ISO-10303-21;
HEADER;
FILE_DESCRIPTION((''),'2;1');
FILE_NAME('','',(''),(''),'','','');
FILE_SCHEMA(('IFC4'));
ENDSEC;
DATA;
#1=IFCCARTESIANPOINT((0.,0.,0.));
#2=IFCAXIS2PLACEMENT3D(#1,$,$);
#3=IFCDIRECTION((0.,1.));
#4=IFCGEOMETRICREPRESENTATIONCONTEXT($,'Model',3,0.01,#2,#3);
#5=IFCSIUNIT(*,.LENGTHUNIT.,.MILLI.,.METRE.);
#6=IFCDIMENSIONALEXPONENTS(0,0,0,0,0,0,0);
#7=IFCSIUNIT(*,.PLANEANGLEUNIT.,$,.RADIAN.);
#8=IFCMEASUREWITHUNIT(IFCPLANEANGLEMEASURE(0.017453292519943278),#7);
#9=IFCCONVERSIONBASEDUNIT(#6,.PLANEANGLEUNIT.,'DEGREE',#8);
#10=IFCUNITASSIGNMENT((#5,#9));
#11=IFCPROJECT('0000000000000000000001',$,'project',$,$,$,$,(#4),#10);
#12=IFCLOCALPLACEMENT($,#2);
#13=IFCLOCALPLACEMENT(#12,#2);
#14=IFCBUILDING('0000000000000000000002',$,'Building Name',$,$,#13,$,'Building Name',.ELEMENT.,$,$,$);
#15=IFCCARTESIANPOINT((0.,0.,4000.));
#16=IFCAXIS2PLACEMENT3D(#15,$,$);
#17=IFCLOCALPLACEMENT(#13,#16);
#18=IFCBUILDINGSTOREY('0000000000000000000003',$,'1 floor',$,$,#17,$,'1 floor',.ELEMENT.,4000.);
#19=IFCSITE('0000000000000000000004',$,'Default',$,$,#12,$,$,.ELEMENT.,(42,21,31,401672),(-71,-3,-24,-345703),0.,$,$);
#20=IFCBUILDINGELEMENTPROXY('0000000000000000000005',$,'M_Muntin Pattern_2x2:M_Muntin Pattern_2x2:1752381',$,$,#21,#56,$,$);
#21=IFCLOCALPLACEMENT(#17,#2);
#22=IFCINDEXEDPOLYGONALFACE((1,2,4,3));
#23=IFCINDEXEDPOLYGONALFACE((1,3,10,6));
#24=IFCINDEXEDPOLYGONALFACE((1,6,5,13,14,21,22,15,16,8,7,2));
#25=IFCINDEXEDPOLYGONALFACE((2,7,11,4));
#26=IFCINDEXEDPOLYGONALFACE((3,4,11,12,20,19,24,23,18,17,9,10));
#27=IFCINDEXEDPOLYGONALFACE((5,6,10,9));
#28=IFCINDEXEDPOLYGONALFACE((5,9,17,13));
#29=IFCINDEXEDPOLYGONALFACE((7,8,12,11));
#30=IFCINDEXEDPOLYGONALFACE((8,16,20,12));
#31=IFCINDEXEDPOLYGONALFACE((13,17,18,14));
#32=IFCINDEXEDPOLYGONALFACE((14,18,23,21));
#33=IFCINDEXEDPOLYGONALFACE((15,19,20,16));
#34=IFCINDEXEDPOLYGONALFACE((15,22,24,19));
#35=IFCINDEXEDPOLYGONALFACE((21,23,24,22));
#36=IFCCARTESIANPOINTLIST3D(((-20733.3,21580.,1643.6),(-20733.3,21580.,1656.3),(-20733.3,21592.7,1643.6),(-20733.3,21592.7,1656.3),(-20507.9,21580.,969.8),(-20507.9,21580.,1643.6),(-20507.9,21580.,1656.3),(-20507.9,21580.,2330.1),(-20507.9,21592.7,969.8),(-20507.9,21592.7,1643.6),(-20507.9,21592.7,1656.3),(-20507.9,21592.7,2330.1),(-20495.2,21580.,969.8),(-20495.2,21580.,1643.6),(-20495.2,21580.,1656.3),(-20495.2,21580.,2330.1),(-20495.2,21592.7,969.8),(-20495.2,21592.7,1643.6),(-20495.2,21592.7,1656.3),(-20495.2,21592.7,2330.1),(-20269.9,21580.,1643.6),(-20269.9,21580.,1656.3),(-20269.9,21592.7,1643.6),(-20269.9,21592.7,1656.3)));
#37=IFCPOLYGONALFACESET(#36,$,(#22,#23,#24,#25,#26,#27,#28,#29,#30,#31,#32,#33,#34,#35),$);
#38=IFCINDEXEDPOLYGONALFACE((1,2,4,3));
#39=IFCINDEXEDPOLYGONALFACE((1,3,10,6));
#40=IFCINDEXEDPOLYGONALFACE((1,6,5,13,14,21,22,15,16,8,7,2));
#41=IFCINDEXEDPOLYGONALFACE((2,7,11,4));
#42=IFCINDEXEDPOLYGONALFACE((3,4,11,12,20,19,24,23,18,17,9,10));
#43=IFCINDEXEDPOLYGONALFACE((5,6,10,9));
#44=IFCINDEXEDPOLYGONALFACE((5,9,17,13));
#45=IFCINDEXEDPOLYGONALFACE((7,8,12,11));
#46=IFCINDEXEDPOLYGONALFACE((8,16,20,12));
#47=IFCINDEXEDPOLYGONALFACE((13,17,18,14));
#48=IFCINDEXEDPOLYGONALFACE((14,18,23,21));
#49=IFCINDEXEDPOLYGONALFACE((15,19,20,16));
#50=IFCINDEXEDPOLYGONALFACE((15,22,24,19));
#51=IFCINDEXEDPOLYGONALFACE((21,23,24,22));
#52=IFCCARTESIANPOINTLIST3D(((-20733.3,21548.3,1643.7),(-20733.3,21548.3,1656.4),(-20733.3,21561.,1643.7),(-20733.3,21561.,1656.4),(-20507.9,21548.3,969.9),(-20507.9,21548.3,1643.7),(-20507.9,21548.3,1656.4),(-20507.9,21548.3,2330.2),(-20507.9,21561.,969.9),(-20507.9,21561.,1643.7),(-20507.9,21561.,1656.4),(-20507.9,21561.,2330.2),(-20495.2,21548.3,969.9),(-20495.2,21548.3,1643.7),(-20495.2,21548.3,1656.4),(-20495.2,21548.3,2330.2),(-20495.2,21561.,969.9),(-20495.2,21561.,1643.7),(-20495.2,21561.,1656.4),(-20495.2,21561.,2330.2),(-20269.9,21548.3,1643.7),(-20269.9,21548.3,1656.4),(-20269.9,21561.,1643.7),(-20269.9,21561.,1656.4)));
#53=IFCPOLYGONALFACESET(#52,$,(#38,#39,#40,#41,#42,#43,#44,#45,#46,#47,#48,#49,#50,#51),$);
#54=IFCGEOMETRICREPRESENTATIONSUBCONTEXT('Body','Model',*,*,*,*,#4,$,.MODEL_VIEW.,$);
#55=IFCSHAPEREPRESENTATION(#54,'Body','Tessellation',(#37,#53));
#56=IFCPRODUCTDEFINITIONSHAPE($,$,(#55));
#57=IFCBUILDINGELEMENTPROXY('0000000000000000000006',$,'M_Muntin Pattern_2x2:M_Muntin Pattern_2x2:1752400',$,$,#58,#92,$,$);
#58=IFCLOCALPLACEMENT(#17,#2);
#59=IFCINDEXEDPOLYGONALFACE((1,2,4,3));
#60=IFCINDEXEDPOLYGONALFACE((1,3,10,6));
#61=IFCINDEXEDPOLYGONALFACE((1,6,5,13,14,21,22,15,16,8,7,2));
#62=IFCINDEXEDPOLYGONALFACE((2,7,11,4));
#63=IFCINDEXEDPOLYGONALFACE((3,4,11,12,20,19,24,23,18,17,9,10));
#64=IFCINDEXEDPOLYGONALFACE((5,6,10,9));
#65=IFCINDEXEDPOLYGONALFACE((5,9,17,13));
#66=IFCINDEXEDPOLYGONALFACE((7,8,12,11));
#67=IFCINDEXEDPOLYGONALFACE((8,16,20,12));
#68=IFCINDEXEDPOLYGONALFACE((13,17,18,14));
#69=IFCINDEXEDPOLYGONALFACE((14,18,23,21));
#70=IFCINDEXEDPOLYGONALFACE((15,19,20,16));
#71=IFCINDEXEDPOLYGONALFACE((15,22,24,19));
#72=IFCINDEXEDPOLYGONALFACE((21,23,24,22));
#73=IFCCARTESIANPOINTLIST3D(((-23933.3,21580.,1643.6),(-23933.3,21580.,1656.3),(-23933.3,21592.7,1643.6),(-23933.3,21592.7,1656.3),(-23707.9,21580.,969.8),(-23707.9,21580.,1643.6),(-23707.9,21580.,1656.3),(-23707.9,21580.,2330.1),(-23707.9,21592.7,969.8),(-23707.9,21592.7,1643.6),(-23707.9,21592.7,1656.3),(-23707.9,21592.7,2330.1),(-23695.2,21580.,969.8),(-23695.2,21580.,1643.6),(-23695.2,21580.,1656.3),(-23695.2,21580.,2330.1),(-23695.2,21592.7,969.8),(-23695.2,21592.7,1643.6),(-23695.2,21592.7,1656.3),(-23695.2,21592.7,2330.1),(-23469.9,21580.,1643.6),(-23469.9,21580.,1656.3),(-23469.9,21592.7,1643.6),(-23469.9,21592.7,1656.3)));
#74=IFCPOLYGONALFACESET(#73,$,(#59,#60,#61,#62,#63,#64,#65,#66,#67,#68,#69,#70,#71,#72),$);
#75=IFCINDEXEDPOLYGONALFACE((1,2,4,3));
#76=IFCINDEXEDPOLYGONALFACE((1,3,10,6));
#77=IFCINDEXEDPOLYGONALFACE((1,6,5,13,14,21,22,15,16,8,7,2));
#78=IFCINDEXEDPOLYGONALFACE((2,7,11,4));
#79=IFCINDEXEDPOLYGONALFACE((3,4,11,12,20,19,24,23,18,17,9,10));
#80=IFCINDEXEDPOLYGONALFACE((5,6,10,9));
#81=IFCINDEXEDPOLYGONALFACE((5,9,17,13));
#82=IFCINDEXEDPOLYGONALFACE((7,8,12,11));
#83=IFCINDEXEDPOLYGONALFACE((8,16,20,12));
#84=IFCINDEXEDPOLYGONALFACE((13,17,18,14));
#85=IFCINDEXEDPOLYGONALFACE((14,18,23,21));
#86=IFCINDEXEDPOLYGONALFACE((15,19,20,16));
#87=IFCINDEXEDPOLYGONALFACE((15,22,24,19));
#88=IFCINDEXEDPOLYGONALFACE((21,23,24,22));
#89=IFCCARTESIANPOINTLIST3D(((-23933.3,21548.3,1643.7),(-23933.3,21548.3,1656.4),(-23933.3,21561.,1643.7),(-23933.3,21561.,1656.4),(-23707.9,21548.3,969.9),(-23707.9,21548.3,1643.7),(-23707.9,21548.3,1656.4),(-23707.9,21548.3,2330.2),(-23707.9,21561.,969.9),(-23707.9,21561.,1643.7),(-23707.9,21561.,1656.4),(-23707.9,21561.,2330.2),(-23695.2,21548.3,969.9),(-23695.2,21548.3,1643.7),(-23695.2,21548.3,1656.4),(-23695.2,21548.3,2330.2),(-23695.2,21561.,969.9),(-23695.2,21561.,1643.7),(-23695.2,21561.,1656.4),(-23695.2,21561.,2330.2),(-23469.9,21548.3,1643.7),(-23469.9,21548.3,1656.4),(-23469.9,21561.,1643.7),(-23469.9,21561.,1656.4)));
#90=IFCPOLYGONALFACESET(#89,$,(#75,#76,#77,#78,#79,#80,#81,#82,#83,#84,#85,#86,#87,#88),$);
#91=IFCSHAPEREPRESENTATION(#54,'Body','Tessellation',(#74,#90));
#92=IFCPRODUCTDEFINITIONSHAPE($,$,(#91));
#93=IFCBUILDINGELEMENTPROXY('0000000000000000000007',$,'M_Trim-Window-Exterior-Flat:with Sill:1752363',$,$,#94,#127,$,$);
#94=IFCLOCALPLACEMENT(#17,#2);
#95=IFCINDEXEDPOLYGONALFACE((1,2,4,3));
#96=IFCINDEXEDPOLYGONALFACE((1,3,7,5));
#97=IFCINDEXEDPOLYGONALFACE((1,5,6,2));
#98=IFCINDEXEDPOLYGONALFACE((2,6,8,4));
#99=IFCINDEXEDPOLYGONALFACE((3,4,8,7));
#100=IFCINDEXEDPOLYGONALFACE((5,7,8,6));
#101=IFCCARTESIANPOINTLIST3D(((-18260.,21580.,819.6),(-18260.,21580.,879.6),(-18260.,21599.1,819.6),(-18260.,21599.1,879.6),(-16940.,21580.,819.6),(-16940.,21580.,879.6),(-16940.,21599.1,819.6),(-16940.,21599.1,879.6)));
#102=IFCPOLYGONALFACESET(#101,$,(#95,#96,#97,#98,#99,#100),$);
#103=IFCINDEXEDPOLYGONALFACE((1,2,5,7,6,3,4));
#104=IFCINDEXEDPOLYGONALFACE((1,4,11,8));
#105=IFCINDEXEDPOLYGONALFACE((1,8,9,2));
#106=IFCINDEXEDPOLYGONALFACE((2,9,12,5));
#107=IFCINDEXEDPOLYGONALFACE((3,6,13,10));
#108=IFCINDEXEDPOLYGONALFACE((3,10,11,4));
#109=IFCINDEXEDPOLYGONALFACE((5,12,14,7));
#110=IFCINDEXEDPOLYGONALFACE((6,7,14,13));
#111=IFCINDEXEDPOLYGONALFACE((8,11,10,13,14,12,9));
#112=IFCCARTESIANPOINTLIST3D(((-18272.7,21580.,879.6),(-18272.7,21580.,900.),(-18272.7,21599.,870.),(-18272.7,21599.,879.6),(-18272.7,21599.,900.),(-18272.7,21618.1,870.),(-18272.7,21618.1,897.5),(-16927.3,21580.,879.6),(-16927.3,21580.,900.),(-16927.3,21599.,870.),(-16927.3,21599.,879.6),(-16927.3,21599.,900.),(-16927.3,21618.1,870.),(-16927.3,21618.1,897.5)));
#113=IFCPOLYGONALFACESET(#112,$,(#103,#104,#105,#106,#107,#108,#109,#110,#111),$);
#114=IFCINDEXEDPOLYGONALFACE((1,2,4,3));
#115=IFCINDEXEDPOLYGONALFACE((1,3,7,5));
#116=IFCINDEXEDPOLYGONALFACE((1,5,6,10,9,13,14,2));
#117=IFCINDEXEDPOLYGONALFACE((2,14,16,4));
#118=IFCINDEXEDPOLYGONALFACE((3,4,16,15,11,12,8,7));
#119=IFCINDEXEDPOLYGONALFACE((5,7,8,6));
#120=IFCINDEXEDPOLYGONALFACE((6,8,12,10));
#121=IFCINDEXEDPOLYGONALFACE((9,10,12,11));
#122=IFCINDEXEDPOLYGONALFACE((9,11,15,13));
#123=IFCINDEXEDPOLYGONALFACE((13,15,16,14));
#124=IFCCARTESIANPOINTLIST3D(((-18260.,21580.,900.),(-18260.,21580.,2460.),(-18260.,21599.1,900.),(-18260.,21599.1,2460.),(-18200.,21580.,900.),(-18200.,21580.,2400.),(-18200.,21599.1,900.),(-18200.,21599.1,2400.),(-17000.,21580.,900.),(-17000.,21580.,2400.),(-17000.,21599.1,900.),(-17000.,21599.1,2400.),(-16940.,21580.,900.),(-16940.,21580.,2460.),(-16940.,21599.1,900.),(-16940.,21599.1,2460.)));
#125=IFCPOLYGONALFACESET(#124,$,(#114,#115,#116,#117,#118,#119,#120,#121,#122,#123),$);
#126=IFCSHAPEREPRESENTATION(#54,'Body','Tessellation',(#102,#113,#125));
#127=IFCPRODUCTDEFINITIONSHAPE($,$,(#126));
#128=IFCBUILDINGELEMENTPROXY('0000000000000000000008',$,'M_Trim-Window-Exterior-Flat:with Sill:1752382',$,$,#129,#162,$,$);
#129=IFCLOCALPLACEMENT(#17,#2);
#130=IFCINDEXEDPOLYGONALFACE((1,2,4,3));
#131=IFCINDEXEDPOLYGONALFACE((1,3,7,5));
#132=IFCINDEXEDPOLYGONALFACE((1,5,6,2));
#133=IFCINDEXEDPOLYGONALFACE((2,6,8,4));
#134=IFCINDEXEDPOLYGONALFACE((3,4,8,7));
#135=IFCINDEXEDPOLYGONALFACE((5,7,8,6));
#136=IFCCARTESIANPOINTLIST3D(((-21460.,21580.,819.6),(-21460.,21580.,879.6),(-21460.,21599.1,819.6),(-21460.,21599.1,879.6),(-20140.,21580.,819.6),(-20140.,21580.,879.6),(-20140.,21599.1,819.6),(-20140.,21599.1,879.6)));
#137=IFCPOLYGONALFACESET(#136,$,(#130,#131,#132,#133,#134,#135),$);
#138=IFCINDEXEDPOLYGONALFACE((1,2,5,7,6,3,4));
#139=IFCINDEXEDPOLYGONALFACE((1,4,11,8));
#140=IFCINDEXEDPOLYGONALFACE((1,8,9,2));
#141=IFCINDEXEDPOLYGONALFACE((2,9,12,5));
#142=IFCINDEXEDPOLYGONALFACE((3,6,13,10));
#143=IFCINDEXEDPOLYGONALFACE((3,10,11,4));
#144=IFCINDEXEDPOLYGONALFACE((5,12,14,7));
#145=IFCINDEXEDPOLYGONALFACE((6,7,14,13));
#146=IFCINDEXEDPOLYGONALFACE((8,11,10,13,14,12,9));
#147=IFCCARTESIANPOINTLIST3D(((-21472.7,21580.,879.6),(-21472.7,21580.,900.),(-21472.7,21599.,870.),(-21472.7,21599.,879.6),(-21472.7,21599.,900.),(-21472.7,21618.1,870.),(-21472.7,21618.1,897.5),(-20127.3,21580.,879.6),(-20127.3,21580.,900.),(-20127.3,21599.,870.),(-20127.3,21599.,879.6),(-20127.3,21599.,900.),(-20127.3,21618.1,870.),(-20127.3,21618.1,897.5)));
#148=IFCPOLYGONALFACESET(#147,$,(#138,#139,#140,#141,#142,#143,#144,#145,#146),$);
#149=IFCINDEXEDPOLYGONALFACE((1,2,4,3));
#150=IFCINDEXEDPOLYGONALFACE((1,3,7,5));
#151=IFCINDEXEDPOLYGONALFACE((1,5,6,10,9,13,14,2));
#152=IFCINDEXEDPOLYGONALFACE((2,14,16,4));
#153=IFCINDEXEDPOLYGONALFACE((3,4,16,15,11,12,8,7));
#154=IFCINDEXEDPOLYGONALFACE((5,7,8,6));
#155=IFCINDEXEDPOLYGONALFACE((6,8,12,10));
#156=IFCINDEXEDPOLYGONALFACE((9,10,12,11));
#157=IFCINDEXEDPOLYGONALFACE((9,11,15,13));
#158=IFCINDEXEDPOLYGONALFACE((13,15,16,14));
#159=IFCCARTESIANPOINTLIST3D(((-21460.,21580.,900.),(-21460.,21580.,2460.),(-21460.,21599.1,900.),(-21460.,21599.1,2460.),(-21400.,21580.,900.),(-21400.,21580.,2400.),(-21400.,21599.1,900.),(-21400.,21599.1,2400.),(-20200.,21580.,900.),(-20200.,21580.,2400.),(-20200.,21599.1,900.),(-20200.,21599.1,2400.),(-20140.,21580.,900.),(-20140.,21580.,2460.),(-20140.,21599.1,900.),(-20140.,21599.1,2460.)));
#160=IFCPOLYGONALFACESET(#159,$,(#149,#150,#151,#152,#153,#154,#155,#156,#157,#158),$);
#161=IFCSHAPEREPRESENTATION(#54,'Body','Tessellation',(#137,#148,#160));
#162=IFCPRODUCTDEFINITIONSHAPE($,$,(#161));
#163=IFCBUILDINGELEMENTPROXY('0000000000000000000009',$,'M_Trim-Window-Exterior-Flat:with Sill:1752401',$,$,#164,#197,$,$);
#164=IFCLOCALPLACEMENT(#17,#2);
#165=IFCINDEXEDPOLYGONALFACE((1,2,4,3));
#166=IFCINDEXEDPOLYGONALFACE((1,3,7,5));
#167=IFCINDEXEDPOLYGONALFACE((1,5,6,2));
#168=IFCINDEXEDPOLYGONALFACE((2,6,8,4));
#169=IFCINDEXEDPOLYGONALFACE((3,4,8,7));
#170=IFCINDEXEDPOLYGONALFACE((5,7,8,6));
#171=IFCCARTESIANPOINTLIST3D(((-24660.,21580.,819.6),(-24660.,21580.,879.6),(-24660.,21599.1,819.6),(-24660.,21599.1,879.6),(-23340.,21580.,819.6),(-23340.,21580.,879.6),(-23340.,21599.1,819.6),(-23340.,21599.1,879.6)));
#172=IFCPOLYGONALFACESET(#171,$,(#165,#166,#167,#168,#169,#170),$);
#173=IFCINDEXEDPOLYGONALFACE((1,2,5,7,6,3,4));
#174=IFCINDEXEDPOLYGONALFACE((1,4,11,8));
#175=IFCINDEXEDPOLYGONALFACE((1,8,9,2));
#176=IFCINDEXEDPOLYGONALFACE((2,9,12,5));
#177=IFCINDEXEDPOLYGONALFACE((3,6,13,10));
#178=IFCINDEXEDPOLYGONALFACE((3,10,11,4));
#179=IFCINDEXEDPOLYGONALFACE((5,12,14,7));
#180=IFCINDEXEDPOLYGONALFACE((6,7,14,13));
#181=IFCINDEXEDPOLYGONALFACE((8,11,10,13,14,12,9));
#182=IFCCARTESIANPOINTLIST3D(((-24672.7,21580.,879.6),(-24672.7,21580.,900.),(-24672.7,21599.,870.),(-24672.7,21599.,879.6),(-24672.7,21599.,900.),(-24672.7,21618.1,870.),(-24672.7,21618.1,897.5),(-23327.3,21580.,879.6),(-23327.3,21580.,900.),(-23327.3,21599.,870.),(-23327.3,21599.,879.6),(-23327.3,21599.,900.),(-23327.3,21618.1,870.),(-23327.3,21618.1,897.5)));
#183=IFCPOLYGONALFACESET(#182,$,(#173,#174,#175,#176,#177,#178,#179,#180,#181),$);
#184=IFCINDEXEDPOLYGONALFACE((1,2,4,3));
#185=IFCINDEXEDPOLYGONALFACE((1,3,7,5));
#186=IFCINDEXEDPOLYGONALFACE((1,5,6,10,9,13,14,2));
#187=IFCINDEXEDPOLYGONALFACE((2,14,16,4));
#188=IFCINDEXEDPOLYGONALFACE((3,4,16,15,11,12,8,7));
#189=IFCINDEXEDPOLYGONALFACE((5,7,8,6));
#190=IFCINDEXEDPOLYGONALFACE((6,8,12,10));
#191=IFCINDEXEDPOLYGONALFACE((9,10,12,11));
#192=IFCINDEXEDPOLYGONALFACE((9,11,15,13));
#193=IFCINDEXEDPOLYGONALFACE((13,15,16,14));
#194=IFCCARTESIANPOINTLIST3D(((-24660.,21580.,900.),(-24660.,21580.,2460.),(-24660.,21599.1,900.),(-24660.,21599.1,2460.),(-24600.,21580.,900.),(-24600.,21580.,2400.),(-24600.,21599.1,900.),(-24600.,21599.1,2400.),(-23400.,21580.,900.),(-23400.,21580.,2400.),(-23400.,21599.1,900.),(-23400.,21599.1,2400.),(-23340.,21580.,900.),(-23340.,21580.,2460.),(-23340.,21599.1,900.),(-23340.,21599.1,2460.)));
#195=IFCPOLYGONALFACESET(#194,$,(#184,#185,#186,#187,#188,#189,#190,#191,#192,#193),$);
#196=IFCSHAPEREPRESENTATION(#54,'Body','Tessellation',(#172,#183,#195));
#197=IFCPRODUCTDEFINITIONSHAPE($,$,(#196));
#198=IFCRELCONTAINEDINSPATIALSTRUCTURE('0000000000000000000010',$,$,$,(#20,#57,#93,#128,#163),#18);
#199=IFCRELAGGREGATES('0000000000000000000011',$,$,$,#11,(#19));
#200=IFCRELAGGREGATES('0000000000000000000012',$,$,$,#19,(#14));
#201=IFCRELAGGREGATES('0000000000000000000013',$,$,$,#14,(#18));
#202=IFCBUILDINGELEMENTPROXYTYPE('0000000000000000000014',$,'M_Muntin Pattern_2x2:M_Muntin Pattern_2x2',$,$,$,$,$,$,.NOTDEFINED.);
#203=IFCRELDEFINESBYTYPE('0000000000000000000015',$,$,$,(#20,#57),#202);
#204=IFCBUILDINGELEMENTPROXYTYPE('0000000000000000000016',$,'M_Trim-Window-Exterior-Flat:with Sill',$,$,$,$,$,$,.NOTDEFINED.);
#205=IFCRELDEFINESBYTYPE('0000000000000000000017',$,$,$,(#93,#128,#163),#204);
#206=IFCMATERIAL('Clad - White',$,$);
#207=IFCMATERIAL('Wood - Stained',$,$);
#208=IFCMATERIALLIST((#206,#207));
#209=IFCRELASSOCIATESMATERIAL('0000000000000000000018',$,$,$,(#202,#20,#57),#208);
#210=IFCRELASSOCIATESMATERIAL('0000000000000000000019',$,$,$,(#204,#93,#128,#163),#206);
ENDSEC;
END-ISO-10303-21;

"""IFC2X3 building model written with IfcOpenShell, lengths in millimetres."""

from ifc_helpers import new_model, entity, si_unit, converted_unit, direction, frame, frame_2d, origin, place, context, subcontext, project, spatial, polyline, rectangle, outline, extrude, source, transform, mapped, material, material_list, type_object, type_shapes, element, save


model = new_model("IFC2X3")

# Units and contexts
model_context = context("Model", 3, precision=0.01, world=origin(), true_north=direction((0.0, 1.0)))
body_context = subcontext(model_context, "Body", "Model", "MODEL_VIEW")
ifc_project = project(units=[si_unit("LENGTHUNIT", "METRE", prefix="MILLI"), converted_unit("PLANEANGLEUNIT", "DEGREE", entity("IfcPlaneAngleMeasure", 0.017453292519943278), si_unit("PLANEANGLEUNIT", "RADIAN"), dimensions=[0, 0, 0, 0, 0, 0, 0])], contexts=[model_context])

# Site, building, storey
site_placement = place(None, origin())
site = spatial("IfcSite", under=ifc_project, at=site_placement, Name="Default", CompositionType="ELEMENT", RefLatitude=(42, 21, 31, 401672), RefLongitude=(-71, -3, -24, -345703), RefElevation=0.0)
building_placement = place(site_placement, origin())
building = spatial("IfcBuilding", under=site, at=building_placement, Name="Building Name", LongName="Building Name", CompositionType="ELEMENT")
storey_placement = place(building_placement, frame((0.0, 0.0, 4000.0)))
storey = spatial("IfcBuildingStorey", under=building, at=storey_placement, Name="1 floor", LongName="1 floor", CompositionType="ELEMENT", Elevation=4000.0)

# Building element proxies
ifc_material_1 = material(Name="Clad - White")
ifc_material_2 = material(Name="Wood - Stained")
ifc_material_list = material_list([ifc_material_1, ifc_material_2])
building_element_proxy_type_1 = type_object("IfcBuildingElementProxyType", Name="M_Muntin Pattern_2x2:M_Muntin Pattern_2x2", PredefinedType="NOTDEFINED", material=ifc_material_list)
shared_shape_1 = source(origin(), body_context, "Body", "SweptSolid", [
    extrude(outline(polyline([(6.4, -6.4), (680.1, -6.4), (680.1, 6.3), (6.4, 6.3), (6.4, 231.7), (-6.3, 231.7), (-6.3, 6.3), (-680.2, 6.3), (-680.2, -6.4), (-6.3, -6.4), (-6.3, -231.7), (6.4, -231.7), (6.4, -6.4)])), frame((0.0, -22.2, 680.1), z_axis=(0.0, 1.0, 0.0), x_axis=(0.0, 0.0, 1.0)), (0.0, 0.0, 1.0), 12.7),
    extrude(outline(polyline([(6.4, -6.4), (680.2, -6.4), (680.2, 6.3), (6.4, 6.3), (6.4, 231.7), (-6.3, 231.7), (-6.3, 6.3), (-680.2, 6.3), (-680.2, -6.4), (-6.3, -6.4), (-6.3, -231.7), (6.4, -231.7), (6.4, -6.4)])), frame((0.0, 9.5, 680.2), z_axis=(0.0, 1.0, 0.0), x_axis=(0.0, 0.0, 1.0)), (0.0, 0.0, 1.0), 12.7),
])
type_shapes(building_element_proxy_type_1, [shared_shape_1])
for number, where, z_axis, x_axis, name in (
    (1, (-20501.6, 21570.5, 969.9), (0.0, 0.0, 1.0), (-1.0, 0.0, 0.0), "M_Muntin Pattern_2x2:M_Muntin Pattern_2x2:1752381"),
    (2, (-23701.6, 21570.5, 969.9), (0.0, 0.0, 1.0), (-1.0, 0.0, 0.0), "M_Muntin Pattern_2x2:M_Muntin Pattern_2x2:1752400"),
):
    element("IfcBuildingElementProxy", number, at=place(storey_placement, frame(where, z_axis=z_axis, x_axis=x_axis)), inside=storey, type_object=building_element_proxy_type_1, material=ifc_material_list, Name=name, context=body_context, shape_type="MappedRepresentation", body=[
        mapped(shared_shape_1, transform((0.0, 0.0, 0.0), scale=1.0)),
    ])
building_element_proxy_type_2 = type_object("IfcBuildingElementProxyType", Name="M_Trim-Window-Exterior-Flat:with Sill", PredefinedType="NOTDEFINED", material=ifc_material_1)
shared_shape_2 = source(origin(), body_context, "Body", "SweptSolid", [
    extrude(rectangle(XDim=1320.0, YDim=60.0, at=frame_2d((0.0, 0.0), x_axis=(1.0, 0.0))), frame((0.0, -1550.4, 0.0), z_axis=(0.0, 0.0, 1.0), x_axis=(-1.0, 0.0, 0.0)), (0.0, 0.0, 1.0), 19.0),
    extrude(outline(polyline([(-19.0, -15.2), (0.0, -15.2), (0.0, -5.7), (19.0, -5.7), (19.0, 14.8), (0.0, 14.8), (-19.0, 12.3), (-19.0, -15.2)])), frame((-672.7, -1514.8, 19.0), z_axis=(1.0, 0.0, 0.0), x_axis=(0.0, 0.0, -1.0)), (0.0, 0.0, 1.0), 1345.4),
    extrude(outline(polyline([(-795.0, -660.0), (765.0, -660.0), (765.0, -600.0), (-735.0, -600.0), (-735.0, 600.0), (765.0, 600.0), (765.0, 660.0), (-795.0, 660.0), (-795.0, -660.0)])), frame((0.0, -735.0, 0.0), z_axis=(0.0, 0.0, 1.0), x_axis=(0.0, -1.0, 0.0)), (0.0, 0.0, 1.0), 19.0),
])
type_shapes(building_element_proxy_type_2, [shared_shape_2])
for number, where, z_axis, x_axis, name in (
    (3, (-17600.0, 21580.0, 2400.0), (0.0, 1.0, 0.0), (-1.0, 0.0, 0.0), "M_Trim-Window-Exterior-Flat:with Sill:1752363"),
    (4, (-20800.0, 21580.0, 2400.0), (0.0, 1.0, 0.0), (-1.0, 0.0, 0.0), "M_Trim-Window-Exterior-Flat:with Sill:1752382"),
    (5, (-24000.0, 21580.0, 2400.0), (0.0, 1.0, 0.0), (-1.0, 0.0, 0.0), "M_Trim-Window-Exterior-Flat:with Sill:1752401"),
):
    element("IfcBuildingElementProxy", number, at=place(storey_placement, frame(where, z_axis=z_axis, x_axis=x_axis)), inside=storey, type_object=building_element_proxy_type_2, material=ifc_material_1, Name=name, context=body_context, shape_type="MappedRepresentation", body=[
        mapped(shared_shape_2, transform((0.0, 0.0, 0.0), scale=1.0)),
    ])

save(model, "model.ifc")
